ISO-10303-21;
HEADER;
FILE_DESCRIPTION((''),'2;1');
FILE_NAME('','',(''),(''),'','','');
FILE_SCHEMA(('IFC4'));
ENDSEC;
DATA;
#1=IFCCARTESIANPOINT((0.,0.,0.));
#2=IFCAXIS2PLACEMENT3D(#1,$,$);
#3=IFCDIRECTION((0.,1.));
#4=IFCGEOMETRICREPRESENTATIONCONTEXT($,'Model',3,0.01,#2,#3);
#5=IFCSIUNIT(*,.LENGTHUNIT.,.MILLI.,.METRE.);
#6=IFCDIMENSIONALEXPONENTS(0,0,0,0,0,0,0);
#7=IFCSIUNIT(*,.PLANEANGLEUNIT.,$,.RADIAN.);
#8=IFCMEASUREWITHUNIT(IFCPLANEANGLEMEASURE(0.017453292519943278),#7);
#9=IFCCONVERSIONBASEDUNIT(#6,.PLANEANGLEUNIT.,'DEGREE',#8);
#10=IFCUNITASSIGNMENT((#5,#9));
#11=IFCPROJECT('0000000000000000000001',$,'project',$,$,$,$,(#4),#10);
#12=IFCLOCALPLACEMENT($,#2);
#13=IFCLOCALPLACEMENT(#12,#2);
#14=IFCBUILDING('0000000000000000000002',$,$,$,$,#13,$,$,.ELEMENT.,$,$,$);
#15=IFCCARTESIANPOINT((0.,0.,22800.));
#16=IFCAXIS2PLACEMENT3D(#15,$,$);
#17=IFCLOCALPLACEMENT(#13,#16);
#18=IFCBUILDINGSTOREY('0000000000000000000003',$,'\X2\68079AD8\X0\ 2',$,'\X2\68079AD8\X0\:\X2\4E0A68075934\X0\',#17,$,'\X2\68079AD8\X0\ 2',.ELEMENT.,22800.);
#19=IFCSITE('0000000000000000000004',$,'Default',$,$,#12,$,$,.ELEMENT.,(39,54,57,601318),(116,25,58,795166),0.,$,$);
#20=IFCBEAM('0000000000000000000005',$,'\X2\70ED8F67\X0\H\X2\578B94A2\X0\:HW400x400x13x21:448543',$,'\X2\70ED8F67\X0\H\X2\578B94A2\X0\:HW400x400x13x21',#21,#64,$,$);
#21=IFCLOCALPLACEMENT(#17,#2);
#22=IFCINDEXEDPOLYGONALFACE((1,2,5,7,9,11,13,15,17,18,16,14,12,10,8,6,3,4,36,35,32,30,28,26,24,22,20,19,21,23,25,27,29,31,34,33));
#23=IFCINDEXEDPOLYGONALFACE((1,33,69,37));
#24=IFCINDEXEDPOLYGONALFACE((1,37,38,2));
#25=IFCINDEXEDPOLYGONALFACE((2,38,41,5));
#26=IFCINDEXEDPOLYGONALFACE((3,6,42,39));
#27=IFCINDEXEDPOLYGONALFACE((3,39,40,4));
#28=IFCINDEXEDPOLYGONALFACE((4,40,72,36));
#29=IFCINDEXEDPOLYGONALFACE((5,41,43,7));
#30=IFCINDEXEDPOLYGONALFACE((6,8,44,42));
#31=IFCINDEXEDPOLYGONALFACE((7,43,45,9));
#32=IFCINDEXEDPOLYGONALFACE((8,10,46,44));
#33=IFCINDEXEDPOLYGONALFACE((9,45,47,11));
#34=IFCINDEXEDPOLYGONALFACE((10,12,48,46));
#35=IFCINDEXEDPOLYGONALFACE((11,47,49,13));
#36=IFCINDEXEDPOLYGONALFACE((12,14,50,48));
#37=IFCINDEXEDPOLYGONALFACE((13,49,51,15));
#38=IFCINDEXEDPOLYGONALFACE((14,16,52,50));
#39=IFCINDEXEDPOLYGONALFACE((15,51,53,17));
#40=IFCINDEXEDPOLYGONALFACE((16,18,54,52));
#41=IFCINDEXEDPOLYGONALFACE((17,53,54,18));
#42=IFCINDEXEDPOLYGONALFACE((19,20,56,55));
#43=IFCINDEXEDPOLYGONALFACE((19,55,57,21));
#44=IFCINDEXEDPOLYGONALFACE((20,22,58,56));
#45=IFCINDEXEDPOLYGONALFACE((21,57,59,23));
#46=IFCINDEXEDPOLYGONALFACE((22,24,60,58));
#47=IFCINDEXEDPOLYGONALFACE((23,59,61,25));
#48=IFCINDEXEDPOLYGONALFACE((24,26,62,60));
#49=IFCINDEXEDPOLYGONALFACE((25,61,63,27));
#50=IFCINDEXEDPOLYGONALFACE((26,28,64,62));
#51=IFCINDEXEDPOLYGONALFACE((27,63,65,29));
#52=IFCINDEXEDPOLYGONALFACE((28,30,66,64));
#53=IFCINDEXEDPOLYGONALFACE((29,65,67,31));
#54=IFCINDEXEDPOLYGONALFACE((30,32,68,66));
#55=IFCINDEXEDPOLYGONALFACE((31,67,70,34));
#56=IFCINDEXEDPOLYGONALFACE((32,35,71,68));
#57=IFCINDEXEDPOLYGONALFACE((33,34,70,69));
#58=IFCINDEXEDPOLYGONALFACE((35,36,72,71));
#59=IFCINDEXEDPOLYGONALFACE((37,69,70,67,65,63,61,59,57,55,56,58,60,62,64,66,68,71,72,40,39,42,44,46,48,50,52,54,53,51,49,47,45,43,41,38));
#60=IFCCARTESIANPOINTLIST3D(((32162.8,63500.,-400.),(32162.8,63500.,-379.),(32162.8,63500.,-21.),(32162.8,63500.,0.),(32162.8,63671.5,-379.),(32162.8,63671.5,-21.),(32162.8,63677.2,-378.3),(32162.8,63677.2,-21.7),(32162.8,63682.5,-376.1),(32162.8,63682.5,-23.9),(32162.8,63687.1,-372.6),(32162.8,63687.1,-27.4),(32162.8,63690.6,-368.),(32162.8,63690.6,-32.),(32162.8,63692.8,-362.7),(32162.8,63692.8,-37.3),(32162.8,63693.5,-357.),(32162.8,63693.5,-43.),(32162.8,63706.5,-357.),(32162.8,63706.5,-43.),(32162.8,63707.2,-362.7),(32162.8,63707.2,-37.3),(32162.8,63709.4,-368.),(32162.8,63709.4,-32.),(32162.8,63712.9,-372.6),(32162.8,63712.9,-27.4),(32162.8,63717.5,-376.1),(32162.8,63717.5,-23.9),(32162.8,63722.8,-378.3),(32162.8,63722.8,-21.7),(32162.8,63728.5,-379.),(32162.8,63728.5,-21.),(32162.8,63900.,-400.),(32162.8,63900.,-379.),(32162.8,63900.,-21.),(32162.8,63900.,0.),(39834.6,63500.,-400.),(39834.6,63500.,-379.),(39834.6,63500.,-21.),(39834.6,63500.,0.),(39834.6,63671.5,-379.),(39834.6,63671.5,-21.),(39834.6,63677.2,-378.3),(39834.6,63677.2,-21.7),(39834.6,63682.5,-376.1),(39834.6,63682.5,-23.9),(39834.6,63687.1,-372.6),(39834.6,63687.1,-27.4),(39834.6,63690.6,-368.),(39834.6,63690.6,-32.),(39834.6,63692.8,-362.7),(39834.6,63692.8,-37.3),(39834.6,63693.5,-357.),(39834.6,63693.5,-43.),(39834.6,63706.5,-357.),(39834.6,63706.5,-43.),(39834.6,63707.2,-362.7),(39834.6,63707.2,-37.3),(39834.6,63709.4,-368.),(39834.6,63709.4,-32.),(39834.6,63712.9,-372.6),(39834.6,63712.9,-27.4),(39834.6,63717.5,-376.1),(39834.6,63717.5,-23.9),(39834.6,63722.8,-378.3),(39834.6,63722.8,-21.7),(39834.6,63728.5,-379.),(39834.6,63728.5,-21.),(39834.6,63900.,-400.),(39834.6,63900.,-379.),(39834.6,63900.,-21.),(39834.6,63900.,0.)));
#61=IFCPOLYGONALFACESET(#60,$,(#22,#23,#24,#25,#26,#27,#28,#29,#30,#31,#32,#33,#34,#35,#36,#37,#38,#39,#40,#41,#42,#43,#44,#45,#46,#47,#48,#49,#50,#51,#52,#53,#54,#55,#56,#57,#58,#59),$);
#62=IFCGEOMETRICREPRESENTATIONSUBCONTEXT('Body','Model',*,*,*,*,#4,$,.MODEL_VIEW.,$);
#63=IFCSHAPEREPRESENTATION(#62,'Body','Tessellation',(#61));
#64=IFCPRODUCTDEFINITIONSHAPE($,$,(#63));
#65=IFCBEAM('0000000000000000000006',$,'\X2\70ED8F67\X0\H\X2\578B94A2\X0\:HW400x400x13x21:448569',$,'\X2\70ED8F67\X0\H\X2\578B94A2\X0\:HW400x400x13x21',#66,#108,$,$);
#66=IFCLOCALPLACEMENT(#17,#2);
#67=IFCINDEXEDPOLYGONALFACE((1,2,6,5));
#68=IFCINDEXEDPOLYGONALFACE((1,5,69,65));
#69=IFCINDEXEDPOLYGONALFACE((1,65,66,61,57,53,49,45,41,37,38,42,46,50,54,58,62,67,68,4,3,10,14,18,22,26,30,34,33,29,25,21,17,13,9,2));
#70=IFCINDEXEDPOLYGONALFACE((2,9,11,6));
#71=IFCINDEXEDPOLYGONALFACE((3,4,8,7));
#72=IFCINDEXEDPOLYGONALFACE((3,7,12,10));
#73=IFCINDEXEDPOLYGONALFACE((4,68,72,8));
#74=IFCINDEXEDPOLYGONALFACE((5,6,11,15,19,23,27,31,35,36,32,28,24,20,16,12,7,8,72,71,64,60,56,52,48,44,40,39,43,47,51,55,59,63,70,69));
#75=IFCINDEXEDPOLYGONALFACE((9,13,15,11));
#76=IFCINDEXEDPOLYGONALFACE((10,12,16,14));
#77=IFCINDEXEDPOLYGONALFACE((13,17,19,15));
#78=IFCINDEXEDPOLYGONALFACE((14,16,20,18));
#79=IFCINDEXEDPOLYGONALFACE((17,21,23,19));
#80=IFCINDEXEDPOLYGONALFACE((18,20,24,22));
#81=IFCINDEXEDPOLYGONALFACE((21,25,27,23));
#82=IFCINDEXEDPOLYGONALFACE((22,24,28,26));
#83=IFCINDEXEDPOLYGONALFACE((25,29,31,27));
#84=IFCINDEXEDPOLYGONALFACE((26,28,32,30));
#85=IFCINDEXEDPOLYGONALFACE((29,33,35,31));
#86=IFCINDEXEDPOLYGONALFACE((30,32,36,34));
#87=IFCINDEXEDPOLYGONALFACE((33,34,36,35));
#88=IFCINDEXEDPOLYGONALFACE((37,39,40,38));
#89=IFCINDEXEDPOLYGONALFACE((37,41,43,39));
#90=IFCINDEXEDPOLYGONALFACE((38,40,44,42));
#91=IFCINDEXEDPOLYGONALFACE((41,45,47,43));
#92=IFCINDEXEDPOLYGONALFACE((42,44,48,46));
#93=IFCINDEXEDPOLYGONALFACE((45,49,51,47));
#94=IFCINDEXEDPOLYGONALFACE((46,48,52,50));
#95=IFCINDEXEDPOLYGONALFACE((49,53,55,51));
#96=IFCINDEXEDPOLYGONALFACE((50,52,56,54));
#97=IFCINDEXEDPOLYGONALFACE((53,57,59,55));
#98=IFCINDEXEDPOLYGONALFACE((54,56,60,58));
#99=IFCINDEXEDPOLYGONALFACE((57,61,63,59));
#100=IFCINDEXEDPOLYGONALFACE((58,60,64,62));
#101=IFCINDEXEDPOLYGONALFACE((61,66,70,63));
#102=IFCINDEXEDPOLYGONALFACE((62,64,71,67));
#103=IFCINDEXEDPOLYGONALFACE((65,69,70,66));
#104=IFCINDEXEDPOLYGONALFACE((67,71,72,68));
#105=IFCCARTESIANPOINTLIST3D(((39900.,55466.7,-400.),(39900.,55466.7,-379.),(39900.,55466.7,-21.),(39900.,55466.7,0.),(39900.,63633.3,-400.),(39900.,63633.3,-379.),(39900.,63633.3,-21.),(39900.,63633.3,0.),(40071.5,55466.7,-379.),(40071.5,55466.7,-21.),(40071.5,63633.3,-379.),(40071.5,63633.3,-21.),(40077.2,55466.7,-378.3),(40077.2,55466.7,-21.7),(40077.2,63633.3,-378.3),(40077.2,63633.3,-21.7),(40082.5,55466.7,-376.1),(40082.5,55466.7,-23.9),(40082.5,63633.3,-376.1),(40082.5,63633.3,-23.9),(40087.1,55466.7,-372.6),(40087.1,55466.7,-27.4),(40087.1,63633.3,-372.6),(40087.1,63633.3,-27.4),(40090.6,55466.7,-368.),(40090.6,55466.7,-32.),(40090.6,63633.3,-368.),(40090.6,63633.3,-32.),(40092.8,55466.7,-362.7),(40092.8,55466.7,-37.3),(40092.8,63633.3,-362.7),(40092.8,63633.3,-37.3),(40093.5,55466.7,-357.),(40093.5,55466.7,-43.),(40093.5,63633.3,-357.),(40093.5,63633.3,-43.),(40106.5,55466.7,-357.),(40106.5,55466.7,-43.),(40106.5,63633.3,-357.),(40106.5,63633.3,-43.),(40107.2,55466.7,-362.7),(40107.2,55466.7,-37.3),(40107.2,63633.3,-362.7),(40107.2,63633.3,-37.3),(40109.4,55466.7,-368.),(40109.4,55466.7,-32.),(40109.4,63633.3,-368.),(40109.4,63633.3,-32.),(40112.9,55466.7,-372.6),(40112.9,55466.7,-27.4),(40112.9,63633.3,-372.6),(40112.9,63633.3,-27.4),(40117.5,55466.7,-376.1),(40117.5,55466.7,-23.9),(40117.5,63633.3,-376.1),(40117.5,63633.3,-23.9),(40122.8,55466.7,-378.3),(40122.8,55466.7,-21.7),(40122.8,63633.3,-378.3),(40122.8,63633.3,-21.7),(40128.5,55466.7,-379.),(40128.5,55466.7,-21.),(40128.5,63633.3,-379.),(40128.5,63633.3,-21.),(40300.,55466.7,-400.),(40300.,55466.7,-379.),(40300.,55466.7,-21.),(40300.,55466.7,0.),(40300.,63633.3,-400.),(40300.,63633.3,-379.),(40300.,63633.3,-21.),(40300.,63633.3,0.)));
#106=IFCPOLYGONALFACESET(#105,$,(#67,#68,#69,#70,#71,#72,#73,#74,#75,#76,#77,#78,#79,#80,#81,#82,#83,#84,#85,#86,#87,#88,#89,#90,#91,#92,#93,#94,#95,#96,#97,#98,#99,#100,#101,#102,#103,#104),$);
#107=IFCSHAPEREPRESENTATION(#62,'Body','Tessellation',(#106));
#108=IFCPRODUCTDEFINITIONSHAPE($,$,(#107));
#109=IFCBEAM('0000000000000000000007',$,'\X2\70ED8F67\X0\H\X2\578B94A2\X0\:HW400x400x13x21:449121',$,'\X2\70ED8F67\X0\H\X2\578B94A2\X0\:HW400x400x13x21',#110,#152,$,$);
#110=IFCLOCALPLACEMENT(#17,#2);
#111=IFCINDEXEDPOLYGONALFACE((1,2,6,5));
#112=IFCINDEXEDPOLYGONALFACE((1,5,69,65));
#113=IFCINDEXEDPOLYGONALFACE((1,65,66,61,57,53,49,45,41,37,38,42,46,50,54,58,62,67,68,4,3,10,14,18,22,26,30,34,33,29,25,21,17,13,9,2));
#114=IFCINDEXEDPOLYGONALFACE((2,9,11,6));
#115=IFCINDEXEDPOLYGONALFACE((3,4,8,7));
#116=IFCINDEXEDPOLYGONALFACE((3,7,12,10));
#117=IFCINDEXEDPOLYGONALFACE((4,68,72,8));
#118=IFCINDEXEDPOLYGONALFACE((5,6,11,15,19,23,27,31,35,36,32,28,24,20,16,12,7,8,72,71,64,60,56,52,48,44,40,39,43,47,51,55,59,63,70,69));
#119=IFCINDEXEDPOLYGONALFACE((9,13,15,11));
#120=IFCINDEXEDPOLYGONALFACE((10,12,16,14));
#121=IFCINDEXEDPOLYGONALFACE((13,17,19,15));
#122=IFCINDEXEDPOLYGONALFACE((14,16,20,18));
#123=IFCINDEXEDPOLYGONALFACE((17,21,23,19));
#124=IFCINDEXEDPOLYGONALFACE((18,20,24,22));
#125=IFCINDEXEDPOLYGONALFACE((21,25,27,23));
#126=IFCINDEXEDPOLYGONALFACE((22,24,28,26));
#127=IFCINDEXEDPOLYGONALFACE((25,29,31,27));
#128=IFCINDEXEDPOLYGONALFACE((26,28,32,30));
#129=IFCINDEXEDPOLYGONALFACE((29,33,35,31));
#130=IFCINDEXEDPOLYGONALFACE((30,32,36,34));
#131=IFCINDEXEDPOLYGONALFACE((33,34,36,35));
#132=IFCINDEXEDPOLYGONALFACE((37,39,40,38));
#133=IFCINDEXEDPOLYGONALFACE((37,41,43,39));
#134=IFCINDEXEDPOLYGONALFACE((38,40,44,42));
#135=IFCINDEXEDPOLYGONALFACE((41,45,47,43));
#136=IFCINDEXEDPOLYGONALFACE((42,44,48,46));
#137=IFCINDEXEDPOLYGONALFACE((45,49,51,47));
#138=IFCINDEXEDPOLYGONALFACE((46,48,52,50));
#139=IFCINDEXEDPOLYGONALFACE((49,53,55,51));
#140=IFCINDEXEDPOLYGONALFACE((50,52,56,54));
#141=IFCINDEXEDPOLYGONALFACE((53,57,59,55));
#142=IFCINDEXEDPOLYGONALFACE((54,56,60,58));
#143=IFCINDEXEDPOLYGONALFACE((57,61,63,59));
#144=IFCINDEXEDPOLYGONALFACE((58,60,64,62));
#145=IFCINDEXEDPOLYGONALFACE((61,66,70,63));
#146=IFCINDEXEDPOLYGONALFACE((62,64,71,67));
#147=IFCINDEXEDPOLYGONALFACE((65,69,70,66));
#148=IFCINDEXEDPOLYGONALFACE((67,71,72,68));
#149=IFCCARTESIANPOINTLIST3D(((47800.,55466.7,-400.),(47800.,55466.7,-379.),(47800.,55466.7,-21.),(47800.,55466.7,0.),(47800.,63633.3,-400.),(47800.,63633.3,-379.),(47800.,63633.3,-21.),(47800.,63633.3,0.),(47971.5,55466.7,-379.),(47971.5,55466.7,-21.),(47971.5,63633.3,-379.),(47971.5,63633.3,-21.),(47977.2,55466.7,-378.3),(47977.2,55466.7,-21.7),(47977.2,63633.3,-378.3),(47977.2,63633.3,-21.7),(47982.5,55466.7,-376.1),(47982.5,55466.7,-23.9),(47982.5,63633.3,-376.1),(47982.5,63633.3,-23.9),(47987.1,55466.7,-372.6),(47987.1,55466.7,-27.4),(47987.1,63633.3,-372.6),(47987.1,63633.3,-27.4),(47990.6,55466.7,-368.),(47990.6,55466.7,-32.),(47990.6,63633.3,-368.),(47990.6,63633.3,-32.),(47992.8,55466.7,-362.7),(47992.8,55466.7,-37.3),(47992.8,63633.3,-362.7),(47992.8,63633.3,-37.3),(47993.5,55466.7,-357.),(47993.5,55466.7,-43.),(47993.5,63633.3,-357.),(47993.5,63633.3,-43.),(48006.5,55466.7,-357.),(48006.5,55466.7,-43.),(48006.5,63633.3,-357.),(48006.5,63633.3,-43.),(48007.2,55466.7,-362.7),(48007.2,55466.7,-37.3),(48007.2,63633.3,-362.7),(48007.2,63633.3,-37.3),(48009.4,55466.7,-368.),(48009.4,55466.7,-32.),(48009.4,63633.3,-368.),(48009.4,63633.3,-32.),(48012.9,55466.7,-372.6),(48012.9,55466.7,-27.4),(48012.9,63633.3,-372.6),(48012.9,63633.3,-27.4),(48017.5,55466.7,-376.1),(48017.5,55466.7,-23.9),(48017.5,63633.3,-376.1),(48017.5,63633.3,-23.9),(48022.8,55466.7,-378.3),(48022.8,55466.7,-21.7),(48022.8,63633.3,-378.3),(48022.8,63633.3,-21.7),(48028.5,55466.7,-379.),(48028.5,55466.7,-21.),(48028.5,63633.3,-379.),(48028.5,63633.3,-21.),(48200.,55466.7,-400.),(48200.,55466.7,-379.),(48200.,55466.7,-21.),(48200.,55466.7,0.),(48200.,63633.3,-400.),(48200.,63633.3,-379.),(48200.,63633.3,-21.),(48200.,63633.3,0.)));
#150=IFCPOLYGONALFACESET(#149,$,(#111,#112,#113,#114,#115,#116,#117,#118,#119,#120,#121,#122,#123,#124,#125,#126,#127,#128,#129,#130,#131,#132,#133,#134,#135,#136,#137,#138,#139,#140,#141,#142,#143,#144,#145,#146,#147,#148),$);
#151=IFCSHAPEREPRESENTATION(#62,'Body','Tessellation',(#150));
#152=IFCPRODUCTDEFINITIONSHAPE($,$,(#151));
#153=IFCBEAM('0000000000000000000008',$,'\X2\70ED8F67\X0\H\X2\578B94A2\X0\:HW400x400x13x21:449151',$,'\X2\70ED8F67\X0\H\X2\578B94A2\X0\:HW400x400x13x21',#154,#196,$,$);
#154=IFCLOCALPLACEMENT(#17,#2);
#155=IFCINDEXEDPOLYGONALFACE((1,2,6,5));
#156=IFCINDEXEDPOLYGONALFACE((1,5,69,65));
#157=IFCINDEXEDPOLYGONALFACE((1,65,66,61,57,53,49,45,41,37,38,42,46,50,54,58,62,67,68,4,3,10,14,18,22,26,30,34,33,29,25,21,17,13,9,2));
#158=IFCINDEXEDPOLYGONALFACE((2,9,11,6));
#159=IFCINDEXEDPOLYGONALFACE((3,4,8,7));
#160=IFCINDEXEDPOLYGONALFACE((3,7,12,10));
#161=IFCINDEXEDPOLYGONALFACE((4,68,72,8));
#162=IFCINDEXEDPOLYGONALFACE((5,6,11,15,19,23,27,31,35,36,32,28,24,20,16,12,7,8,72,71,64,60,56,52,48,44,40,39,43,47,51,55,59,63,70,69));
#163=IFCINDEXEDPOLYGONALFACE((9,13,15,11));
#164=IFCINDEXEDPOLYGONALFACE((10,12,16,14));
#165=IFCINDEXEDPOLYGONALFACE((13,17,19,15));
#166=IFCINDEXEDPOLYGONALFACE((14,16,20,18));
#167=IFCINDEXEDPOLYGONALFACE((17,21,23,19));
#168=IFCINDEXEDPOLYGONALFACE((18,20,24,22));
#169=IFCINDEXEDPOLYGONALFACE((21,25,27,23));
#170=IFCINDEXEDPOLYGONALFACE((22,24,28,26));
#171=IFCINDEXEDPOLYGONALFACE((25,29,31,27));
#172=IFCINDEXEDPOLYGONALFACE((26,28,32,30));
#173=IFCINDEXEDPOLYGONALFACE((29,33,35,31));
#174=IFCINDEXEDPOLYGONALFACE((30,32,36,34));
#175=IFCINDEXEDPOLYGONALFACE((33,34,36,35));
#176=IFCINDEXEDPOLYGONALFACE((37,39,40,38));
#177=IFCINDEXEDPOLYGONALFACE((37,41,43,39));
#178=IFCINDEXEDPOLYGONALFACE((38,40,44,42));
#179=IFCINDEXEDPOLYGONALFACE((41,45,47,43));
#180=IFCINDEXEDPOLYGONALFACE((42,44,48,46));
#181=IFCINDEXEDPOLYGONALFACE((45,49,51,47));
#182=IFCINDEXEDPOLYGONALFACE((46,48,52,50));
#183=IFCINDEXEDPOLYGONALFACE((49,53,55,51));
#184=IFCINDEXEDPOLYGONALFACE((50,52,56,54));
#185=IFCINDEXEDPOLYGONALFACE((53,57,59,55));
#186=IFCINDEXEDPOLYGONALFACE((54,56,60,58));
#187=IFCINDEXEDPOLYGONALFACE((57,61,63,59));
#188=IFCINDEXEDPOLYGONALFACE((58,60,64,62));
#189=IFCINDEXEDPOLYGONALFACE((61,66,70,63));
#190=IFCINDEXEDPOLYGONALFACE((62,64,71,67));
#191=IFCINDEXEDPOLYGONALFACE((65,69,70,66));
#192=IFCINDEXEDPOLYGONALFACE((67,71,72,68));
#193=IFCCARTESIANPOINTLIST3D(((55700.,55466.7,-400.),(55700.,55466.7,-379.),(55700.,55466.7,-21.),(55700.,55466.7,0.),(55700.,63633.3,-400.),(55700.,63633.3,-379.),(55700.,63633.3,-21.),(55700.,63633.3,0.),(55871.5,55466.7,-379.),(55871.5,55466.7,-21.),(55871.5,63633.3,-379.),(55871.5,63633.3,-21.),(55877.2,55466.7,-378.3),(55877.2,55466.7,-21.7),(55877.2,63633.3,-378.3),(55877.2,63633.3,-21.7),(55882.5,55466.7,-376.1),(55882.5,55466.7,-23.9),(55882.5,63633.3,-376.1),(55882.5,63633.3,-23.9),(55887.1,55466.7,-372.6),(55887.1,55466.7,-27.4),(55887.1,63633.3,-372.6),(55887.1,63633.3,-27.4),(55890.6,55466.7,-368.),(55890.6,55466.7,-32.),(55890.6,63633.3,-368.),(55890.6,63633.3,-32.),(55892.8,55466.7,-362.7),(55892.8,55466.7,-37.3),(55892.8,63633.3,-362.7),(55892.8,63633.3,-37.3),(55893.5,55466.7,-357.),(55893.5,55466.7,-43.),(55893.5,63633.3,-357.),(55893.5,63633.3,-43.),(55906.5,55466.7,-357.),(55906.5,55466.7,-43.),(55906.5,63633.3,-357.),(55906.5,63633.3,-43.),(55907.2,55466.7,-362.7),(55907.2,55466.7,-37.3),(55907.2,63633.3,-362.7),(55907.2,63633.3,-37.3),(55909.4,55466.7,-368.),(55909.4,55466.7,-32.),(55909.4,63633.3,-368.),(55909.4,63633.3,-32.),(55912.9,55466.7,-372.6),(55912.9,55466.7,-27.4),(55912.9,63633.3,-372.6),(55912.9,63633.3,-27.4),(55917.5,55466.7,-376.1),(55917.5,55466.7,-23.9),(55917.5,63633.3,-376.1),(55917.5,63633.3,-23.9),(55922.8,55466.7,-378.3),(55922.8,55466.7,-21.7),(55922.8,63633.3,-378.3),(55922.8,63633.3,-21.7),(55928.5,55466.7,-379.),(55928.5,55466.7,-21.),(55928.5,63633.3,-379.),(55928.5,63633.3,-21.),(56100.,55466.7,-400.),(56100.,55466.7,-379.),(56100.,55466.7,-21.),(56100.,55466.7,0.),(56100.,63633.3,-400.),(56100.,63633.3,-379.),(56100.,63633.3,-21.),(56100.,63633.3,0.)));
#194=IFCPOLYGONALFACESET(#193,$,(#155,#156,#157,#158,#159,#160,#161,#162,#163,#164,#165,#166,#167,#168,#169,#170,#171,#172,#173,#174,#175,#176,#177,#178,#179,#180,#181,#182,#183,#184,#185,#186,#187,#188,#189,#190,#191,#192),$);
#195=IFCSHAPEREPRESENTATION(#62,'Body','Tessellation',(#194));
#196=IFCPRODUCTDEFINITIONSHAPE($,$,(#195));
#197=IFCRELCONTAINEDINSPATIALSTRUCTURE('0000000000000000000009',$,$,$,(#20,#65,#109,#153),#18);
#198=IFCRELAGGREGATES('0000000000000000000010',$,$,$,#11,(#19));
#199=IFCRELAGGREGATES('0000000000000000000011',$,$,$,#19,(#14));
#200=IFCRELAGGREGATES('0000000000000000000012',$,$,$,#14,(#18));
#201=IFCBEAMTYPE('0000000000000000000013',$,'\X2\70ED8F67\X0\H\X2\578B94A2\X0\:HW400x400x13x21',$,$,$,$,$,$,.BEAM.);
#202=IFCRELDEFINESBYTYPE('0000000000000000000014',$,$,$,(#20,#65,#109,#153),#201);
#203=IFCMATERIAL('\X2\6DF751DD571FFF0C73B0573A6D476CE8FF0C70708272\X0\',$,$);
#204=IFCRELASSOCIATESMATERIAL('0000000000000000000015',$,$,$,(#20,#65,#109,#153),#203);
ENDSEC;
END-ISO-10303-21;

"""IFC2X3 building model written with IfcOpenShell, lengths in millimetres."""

from ifc_helpers import new_model, entity, si_unit, converted_unit, direction, frame, frame_2d, origin, place, context, subcontext, project, spatial, i_section, extrude, material, type_object, element, save


model = new_model("IFC2X3")

# Units and contexts
model_context = context("Model", 3, precision=0.01, world=origin(), true_north=direction((0.0, 1.0)))
body_context = subcontext(model_context, "Body", "Model", "MODEL_VIEW")
ifc_project = project(units=[si_unit("LENGTHUNIT", "METRE", prefix="MILLI"), converted_unit("PLANEANGLEUNIT", "DEGREE", entity("IfcPlaneAngleMeasure", 0.017453292519943278), si_unit("PLANEANGLEUNIT", "RADIAN"), dimensions=[0, 0, 0, 0, 0, 0, 0])], contexts=[model_context])

# Site, building, storey
site_placement = place(None, origin())
site = spatial("IfcSite", under=ifc_project, at=site_placement, Name="Default", CompositionType="ELEMENT", RefLatitude=(39, 54, 57, 601318), RefLongitude=(116, 25, 58, 795166), RefElevation=0.0)
building_placement = place(site_placement, origin())
building = spatial("IfcBuilding", under=site, at=building_placement, CompositionType="ELEMENT")
storey_placement = place(building_placement, frame((0.0, 0.0, 22800.0)))
storey = spatial("IfcBuildingStorey", under=building, at=storey_placement, Name="标高 2", ObjectType="标高:上标头", LongName="标高 2", CompositionType="ELEMENT", Elevation=22800.0)

# Beams
ifc_material = material(Name="混凝土，现场浇注，灰色")
beam_type = type_object("IfcBeamType", Name="热轧H型钢:HW400x400x13x21", PredefinedType="BEAM")
beam_1_placement = place(storey_placement, frame((40100.0, 63700.0, 0.0), z_axis=(0.0, 0.0, 1.0), x_axis=(-1.0, 0.0, 0.0)))
element("IfcBeam", 1, at=beam_1_placement, inside=storey, type_object=beam_type, material=ifc_material, Name="热轧H型钢:HW400x400x13x21:448543", ObjectType="热轧H型钢:HW400x400x13x21", context=body_context, shape_type="SweptSolid", body=[
    extrude(i_section(OverallWidth=400.0, OverallDepth=400.0, WebThickness=13.0, FlangeThickness=21.0, FilletRadius=22.0, at=frame_2d((0.0, 0.0), x_axis=(0.0, 1.0))), frame((265.4, 0.0, -200.0), z_axis=(1.0, 0.0, 0.0), x_axis=(0.0, 0.0, -1.0)), (0.0, 0.0, 1.0), 7671.8),
])
beam_2_placement = place(storey_placement, frame((40100.0, 63700.0, 0.0), z_axis=(0.0, 0.0, 1.0), x_axis=(0.0, -1.0, 0.0)))
element("IfcBeam", 2, at=beam_2_placement, inside=storey, type_object=beam_type, material=ifc_material, Name="热轧H型钢:HW400x400x13x21:448569", ObjectType="热轧H型钢:HW400x400x13x21", context=body_context, shape_type="SweptSolid", body=[
    extrude(i_section(OverallWidth=400.0, OverallDepth=400.0, WebThickness=13.0, FlangeThickness=21.0, FilletRadius=22.0, at=frame_2d((0.0, 0.0), x_axis=(0.0, 1.0))), frame((66.7, 0.0, -200.0), z_axis=(1.0, 0.0, 0.0), x_axis=(0.0, 0.0, -1.0)), (0.0, 0.0, 1.0), 8166.6),
])
beam_3_placement = place(storey_placement, frame((48000.0, 63700.0, 0.0), z_axis=(0.0, 0.0, 1.0), x_axis=(0.0, -1.0, 0.0)))
element("IfcBeam", 3, at=beam_3_placement, inside=storey, type_object=beam_type, material=ifc_material, Name="热轧H型钢:HW400x400x13x21:449121", ObjectType="热轧H型钢:HW400x400x13x21", context=body_context, shape_type="SweptSolid", body=[
    extrude(i_section(OverallWidth=400.0, OverallDepth=400.0, WebThickness=13.0, FlangeThickness=21.0, FilletRadius=22.0, at=frame_2d((0.0, 0.0), x_axis=(0.0, 1.0))), frame((66.7, 0.0, -200.0), z_axis=(1.0, 0.0, 0.0), x_axis=(0.0, 0.0, -1.0)), (0.0, 0.0, 1.0), 8166.6),
])
beam_4_placement = place(storey_placement, frame((55900.0, 63700.0, 0.0), z_axis=(0.0, 0.0, 1.0), x_axis=(0.0, -1.0, 0.0)))
element("IfcBeam", 4, at=beam_4_placement, inside=storey, type_object=beam_type, material=ifc_material, Name="热轧H型钢:HW400x400x13x21:449151", ObjectType="热轧H型钢:HW400x400x13x21", context=body_context, shape_type="SweptSolid", body=[
    extrude(i_section(OverallWidth=400.0, OverallDepth=400.0, WebThickness=13.0, FlangeThickness=21.0, FilletRadius=22.0, at=frame_2d((0.0, 0.0), x_axis=(0.0, 1.0))), frame((66.7, 0.0, -200.0), z_axis=(1.0, 0.0, 0.0), x_axis=(0.0, 0.0, -1.0)), (0.0, 0.0, 1.0), 8166.6),
])

save(model, "model.ifc")
